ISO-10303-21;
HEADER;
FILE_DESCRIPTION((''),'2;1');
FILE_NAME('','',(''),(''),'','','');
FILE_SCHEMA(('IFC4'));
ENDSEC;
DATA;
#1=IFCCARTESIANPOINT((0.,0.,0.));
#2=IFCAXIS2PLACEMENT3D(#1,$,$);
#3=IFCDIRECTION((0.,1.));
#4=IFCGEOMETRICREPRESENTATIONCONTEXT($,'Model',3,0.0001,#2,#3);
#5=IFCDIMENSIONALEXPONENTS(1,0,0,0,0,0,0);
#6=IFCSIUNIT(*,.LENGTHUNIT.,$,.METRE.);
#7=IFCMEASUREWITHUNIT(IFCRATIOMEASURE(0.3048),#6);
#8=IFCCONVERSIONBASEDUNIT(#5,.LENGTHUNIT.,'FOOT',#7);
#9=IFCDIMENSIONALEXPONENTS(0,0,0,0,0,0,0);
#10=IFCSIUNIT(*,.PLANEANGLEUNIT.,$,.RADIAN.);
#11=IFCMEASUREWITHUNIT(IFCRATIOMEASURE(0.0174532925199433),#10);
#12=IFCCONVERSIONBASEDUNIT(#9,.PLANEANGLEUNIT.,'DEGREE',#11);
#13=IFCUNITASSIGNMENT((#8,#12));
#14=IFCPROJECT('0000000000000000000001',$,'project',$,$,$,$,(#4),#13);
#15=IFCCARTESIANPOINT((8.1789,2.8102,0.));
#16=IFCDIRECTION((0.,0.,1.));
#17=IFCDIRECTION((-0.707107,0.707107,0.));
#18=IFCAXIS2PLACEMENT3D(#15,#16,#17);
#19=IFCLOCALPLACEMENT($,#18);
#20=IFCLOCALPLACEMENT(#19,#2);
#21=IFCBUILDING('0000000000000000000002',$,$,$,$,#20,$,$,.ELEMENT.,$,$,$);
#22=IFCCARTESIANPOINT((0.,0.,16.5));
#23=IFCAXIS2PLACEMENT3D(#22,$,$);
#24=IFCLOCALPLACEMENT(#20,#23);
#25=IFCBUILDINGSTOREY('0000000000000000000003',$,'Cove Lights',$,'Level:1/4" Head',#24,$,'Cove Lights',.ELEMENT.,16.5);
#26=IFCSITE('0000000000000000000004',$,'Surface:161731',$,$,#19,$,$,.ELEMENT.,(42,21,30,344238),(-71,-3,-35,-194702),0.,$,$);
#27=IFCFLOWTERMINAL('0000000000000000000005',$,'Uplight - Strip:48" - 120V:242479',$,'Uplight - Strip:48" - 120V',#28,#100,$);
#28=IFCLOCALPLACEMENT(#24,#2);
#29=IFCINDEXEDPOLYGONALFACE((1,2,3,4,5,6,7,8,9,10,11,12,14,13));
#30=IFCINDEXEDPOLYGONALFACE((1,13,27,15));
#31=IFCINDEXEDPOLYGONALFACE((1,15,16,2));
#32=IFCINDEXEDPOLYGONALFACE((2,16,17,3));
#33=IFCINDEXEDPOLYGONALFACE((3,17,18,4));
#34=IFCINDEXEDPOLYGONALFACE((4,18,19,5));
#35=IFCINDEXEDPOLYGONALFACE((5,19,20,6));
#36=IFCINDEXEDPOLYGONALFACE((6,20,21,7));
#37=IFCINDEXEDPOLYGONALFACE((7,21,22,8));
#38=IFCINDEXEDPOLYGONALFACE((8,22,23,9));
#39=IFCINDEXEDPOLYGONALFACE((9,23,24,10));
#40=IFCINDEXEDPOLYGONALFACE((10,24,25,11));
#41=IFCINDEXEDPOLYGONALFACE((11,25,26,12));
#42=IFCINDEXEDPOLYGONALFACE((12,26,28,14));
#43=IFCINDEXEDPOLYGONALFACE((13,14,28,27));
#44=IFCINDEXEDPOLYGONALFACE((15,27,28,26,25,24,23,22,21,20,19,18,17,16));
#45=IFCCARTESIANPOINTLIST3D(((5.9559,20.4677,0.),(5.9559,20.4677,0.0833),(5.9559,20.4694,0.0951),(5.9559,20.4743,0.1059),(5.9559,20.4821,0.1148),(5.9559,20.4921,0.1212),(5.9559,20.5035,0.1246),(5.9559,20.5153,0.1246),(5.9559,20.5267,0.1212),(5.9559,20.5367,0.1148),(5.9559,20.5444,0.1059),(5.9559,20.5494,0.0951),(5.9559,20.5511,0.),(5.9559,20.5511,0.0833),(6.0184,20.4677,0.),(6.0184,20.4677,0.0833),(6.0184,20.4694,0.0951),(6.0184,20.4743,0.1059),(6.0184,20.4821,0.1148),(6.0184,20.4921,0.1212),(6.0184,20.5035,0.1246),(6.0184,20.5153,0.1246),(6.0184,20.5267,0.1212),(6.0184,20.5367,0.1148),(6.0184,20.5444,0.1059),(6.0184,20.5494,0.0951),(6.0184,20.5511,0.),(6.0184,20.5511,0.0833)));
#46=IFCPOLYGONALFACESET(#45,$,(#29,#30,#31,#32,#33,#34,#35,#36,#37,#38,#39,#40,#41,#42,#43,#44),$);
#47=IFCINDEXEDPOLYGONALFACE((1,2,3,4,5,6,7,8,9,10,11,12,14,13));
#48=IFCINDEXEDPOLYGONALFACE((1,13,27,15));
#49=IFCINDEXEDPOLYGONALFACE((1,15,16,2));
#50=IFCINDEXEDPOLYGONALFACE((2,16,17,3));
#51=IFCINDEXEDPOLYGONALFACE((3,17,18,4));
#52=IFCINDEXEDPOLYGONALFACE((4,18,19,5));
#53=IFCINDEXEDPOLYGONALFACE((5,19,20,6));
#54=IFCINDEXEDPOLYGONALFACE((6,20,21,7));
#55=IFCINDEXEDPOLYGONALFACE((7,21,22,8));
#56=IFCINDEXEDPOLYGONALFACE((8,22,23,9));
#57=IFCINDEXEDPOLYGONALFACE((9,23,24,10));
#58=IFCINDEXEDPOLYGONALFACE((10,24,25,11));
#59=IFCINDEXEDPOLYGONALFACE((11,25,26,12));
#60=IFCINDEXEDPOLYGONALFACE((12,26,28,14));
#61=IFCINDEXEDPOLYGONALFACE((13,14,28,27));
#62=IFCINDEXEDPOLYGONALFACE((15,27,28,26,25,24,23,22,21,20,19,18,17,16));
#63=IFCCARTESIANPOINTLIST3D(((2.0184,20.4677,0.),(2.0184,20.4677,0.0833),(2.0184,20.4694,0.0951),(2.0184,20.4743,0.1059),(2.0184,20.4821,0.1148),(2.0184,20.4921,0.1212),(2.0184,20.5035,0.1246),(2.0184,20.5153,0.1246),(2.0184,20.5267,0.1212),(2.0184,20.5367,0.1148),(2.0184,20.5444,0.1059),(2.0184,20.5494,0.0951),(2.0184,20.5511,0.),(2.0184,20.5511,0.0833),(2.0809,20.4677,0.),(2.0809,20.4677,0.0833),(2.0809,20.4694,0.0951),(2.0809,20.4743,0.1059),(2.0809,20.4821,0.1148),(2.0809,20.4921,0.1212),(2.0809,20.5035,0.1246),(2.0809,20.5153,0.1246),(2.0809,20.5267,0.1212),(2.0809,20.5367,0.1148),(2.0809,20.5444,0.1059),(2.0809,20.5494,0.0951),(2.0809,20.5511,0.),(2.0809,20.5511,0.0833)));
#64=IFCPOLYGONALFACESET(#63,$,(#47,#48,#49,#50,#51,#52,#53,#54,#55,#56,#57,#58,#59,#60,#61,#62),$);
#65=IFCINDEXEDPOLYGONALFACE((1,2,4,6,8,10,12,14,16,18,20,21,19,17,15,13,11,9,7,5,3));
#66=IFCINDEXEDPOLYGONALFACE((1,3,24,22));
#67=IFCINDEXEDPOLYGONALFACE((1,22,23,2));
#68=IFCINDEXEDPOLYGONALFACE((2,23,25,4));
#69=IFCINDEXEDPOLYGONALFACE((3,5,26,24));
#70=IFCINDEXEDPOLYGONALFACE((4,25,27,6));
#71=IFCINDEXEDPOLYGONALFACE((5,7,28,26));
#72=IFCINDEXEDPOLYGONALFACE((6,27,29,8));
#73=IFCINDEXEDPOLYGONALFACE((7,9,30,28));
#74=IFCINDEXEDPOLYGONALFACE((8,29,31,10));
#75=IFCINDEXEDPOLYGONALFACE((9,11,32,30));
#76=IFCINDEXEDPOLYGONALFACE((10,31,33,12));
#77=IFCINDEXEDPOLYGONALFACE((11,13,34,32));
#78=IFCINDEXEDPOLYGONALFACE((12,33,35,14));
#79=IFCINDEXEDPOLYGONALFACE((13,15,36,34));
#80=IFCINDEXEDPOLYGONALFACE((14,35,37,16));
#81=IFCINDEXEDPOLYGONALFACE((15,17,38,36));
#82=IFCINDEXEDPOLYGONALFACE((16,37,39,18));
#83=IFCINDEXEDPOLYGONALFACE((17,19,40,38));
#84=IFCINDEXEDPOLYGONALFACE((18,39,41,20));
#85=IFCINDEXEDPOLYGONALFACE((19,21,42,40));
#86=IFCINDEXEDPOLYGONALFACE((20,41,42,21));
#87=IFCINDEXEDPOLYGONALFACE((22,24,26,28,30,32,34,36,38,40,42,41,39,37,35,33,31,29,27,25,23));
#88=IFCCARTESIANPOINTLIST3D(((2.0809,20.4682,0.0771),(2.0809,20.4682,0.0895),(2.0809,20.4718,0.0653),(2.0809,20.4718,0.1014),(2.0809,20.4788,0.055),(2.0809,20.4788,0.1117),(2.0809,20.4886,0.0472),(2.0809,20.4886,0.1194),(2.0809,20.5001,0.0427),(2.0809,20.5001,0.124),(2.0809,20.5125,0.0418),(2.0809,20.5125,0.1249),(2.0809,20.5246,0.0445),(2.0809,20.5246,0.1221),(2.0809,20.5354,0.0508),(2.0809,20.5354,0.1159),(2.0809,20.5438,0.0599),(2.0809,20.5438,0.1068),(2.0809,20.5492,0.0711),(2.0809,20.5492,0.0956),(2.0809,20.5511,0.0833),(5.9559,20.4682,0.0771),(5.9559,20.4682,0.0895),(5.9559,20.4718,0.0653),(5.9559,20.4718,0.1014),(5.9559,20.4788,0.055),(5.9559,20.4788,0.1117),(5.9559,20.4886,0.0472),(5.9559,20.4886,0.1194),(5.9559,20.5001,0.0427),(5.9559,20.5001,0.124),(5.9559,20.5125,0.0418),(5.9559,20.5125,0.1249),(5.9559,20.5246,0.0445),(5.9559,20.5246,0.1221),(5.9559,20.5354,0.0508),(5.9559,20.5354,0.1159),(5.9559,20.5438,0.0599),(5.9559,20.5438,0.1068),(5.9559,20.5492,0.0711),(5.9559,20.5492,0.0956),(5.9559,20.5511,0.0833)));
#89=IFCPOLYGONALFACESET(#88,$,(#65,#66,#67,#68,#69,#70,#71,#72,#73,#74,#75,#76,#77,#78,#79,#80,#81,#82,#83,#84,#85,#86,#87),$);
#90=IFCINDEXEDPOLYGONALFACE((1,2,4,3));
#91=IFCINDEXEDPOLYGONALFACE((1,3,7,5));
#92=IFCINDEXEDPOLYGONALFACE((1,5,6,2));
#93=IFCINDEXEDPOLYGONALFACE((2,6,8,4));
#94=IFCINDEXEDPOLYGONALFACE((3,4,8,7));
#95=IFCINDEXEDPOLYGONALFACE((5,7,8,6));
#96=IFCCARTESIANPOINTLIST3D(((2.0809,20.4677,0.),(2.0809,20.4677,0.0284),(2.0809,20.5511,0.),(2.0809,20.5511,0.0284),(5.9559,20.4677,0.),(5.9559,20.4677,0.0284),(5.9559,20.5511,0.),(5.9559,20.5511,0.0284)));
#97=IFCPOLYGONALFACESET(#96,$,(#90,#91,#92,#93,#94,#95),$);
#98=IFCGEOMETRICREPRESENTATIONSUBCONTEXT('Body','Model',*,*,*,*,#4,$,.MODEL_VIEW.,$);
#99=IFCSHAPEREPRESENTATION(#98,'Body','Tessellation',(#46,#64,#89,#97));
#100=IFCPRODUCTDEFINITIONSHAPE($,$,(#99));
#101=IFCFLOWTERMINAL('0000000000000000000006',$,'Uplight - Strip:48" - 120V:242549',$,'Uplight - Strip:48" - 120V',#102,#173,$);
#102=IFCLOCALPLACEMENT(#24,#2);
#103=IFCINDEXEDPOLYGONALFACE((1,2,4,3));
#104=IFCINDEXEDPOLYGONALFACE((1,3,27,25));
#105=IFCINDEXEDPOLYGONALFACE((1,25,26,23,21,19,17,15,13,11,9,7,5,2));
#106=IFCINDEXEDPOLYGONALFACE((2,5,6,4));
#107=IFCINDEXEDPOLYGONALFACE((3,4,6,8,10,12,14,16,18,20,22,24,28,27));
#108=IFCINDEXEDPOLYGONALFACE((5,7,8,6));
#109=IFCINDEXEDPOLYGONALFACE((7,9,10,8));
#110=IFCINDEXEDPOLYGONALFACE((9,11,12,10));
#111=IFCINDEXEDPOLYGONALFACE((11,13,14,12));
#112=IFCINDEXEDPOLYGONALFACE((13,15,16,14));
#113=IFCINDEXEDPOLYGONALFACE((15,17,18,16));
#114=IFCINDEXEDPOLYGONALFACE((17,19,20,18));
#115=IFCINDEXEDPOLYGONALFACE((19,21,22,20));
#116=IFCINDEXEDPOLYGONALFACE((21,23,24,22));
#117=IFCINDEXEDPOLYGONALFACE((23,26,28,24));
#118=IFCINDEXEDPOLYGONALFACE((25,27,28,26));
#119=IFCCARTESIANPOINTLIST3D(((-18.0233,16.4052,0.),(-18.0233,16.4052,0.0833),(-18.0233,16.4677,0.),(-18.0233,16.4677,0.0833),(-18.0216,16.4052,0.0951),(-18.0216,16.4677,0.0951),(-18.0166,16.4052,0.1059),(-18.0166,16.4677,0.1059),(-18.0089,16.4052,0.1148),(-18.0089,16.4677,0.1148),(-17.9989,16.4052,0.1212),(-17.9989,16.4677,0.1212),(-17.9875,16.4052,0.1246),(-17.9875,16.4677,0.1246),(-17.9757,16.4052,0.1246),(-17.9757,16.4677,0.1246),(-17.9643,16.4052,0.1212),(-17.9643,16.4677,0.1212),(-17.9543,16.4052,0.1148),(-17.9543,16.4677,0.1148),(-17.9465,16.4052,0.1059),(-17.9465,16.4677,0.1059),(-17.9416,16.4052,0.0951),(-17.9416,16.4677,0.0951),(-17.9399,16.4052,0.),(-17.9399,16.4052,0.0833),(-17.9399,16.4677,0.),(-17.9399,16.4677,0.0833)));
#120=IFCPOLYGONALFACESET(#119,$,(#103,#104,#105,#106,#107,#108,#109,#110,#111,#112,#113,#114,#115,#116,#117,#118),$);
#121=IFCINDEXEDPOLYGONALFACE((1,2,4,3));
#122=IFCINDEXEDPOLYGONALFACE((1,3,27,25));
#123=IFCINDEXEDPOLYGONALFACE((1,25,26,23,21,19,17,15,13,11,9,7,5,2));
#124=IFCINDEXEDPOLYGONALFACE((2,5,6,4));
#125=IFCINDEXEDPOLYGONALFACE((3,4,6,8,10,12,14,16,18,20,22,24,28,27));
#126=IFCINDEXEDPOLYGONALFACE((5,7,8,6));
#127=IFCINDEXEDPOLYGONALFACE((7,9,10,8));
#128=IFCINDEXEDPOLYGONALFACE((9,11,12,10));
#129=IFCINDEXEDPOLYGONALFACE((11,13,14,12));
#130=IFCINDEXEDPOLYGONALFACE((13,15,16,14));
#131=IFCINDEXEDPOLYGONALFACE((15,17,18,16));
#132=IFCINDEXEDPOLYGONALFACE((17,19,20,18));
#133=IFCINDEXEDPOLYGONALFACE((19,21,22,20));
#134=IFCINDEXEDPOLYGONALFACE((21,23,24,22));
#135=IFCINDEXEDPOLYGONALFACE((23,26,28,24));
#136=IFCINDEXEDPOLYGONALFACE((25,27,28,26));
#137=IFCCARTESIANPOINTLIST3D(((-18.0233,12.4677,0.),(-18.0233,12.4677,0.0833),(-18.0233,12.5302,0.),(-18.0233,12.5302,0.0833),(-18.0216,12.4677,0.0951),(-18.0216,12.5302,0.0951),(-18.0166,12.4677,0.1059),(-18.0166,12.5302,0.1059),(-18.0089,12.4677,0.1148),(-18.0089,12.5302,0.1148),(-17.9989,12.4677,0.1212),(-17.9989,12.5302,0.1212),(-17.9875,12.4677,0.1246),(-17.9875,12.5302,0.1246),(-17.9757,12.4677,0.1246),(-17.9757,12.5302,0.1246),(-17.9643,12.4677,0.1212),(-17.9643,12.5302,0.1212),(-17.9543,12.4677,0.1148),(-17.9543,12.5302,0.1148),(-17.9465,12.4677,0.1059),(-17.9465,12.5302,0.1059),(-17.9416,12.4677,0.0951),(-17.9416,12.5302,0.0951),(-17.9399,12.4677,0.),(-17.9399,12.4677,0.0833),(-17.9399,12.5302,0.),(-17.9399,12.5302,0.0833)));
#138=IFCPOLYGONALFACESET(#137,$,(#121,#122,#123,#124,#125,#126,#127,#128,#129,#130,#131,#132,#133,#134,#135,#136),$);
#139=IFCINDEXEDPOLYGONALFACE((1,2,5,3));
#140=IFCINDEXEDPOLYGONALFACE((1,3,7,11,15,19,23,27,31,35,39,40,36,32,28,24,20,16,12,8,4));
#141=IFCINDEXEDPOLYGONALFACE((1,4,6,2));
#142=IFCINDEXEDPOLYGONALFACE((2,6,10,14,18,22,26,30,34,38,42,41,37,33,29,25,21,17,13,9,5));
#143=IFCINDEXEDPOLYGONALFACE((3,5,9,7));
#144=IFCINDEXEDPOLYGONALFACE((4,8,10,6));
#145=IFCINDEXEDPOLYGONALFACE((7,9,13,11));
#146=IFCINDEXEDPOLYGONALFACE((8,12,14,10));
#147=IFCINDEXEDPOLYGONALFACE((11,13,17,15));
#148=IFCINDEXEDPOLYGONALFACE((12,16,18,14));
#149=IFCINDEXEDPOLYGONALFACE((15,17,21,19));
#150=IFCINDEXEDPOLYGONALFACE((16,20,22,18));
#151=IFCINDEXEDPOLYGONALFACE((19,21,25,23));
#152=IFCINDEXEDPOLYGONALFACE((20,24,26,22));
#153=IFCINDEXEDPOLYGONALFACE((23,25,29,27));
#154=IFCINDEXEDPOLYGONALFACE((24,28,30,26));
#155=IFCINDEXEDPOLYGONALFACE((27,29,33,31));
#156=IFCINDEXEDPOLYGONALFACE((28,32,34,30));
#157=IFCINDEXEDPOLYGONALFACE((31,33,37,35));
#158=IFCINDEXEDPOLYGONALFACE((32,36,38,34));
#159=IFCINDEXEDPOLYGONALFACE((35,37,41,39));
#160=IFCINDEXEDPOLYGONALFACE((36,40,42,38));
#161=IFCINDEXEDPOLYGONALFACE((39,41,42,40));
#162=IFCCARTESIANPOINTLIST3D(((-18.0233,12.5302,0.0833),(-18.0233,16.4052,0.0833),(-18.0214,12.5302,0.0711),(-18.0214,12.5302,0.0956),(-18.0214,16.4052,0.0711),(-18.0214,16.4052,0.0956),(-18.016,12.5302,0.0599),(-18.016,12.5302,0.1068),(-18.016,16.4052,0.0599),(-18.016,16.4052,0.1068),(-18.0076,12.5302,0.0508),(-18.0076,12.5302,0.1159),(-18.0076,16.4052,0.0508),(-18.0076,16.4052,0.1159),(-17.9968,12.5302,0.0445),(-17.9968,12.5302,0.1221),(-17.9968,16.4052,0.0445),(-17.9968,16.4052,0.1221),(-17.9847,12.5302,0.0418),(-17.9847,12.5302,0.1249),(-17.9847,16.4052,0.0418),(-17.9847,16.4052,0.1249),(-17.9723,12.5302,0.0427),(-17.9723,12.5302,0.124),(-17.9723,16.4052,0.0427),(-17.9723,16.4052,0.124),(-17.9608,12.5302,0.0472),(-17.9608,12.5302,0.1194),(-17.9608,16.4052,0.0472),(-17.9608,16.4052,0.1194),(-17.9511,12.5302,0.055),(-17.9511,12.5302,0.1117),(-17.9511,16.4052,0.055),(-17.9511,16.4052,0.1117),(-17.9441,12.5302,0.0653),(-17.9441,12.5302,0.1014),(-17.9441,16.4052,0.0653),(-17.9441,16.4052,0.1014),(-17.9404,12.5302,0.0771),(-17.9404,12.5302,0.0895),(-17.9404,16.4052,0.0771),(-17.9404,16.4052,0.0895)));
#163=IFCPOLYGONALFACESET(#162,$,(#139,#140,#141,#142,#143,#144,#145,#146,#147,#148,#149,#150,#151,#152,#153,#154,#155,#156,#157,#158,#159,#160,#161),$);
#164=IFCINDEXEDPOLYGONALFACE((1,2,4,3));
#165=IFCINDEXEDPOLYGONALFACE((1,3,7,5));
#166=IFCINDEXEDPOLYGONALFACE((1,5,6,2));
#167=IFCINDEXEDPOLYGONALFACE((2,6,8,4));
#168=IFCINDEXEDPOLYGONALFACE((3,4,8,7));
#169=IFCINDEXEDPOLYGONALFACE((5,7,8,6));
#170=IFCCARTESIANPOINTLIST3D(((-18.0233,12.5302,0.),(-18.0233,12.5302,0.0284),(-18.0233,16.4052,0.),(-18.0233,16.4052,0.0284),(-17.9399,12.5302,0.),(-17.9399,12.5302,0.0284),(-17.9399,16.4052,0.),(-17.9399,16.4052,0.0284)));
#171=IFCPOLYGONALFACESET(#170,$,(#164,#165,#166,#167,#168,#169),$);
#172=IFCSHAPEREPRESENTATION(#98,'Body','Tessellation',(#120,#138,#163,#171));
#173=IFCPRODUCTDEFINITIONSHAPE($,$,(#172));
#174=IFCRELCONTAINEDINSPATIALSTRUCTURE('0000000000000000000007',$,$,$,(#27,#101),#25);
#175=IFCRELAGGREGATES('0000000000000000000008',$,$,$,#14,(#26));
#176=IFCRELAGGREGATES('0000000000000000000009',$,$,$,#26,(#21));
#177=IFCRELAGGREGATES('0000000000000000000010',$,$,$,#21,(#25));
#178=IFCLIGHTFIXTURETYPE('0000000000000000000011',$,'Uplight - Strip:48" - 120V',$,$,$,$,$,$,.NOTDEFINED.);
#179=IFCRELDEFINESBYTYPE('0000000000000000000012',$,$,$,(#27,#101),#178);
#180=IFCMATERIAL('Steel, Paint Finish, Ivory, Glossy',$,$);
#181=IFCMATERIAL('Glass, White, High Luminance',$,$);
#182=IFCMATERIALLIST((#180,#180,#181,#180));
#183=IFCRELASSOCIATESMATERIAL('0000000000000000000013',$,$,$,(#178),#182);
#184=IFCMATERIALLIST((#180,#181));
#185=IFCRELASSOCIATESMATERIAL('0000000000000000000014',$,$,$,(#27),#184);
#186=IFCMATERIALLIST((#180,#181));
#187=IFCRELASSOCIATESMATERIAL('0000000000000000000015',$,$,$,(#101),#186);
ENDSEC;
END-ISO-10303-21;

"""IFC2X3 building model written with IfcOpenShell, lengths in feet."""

from ifc_helpers import new_model, entity, si_unit, converted_unit, direction, frame, frame_2d, origin, origin_2d_with_axis, place, context, subcontext, project, spatial, polyline, circle_curve, parameter, trimmed, segment, composite_curve, rectangle, circle, outline, extrude, source, transform, mapped, material, material_list, type_object, type_shapes, element, save


model = new_model("IFC2X3")

# Units and contexts
model_context = context("Model", 3, precision=0.0001, world=origin(), true_north=direction((0.0, 1.0)))
body_context = subcontext(model_context, "Body", "Model", "MODEL_VIEW")
ifc_project = project(units=[converted_unit("LENGTHUNIT", "FOOT", entity("IfcRatioMeasure", 0.3048), si_unit("LENGTHUNIT", "METRE"), dimensions=[1, 0, 0, 0, 0, 0, 0]), converted_unit("PLANEANGLEUNIT", "DEGREE", entity("IfcRatioMeasure", 0.0174532925199433), si_unit("PLANEANGLEUNIT", "RADIAN"), dimensions=[0, 0, 0, 0, 0, 0, 0])], contexts=[model_context])

# Site, building, storey
site_placement = place(None, frame((8.1789, 2.8102, 0.0), z_axis=(0.0, 0.0, 1.0), x_axis=(-0.707107, 0.707107, 0.0)))
site = spatial("IfcSite", under=ifc_project, at=site_placement, Name="Surface:161731", CompositionType="ELEMENT", RefLatitude=(42, 21, 30, 344238), RefLongitude=(-71, -3, -35, -194702), RefElevation=0.0)
building_placement = place(site_placement, origin())
building = spatial("IfcBuilding", under=site, at=building_placement, CompositionType="ELEMENT")
storey_placement = place(building_placement, frame((0.0, 0.0, 16.5)))
storey = spatial("IfcBuildingStorey", under=building, at=storey_placement, Name="Cove Lights", ObjectType="Level:1/4\" Head", LongName="Cove Lights", CompositionType="ELEMENT", Elevation=16.5)

# Flow terminals
ifc_material_1 = material(Name="Steel, Paint Finish, Ivory, Glossy")
ifc_material_2 = material(Name="Glass, White, High Luminance")
ifc_material_list_1 = material_list([ifc_material_1, ifc_material_1, ifc_material_2, ifc_material_1])
light_fixture_type_1 = type_object("IfcLightFixtureType", Name="Uplight - Strip:48\" - 120V", PredefinedType="NOTDEFINED", material=ifc_material_list_1)
shared_shape_1 = source(origin(), body_context, "Body", "SweptSolid", [
    extrude(outline(composite_curve([segment(polyline([(-0.0417, -0.0417), (0.0417, -0.0417)]), True, "CONTINUOUS"), segment(trimmed(circle_curve(frame_2d((0.0417, 0.0), x_axis=(0.0, -1.0)), 0.0417), [parameter(0.0)], [parameter(180.0)], True, "PARAMETER"), True, "CONTINUOUS"), segment(polyline([(0.0417, 0.0417), (-0.0417, 0.0417)]), True, "CONTINUOUS"), segment(polyline([(-0.0417, 0.0417), (-0.0417, -0.0417)]), True, "CONTINUOUS")], self_intersect=False)), frame((1.9375, 0.0, 0.0417), z_axis=(1.0, 0.0, 0.0), x_axis=(0.0, 0.0, 1.0)), (0.0, 0.0, 1.0), 0.0625),
    extrude(outline(composite_curve([segment(polyline([(-0.0417, -0.0417), (0.0417, -0.0417)]), True, "CONTINUOUS"), segment(polyline([(0.0417, -0.0417), (0.0417, 0.0417)]), True, "CONTINUOUS"), segment(trimmed(circle_curve(frame_2d((0.0, 0.0417), x_axis=(0.0, 1.0)), 0.0417), [parameter(270.0)], [parameter(90.0)], True, "PARAMETER"), True, "CONTINUOUS"), segment(polyline([(-0.0417, 0.0417), (-0.0417, -0.0417)]), True, "CONTINUOUS")], self_intersect=False)), frame((-2.0, 0.0, 0.0417), z_axis=(1.0, 0.0, 0.0), x_axis=(0.0, 1.0, 0.0)), (0.0, 0.0, 1.0), 0.0625),
    extrude(circle(Radius=0.0417, at=frame_2d((0.0, 0.0), x_axis=(1.0, 0.0))), frame((-1.9375, 0.0, 0.0833), z_axis=(1.0, 0.0, 0.0), x_axis=(0.0, 1.0, 0.0)), (0.0, 0.0, 1.0), 3.875),
    extrude(rectangle(XDim=3.875, YDim=0.0833, at=origin_2d_with_axis()), frame((0.0, 0.0, 0.0), z_axis=(0.0, 0.0, 1.0), x_axis=(-1.0, 0.0, 0.0)), (0.0, 0.0, 1.0), 0.0284),
])
type_shapes(light_fixture_type_1, [shared_shape_1])
ifc_material_list_2 = material_list([ifc_material_1, ifc_material_2])
flow_terminal_1_placement = place(storey_placement, frame((4.0184, 20.5094, 0.0)))
element("IfcFlowTerminal", 1, at=flow_terminal_1_placement, inside=storey, type_object=light_fixture_type_1, material=ifc_material_list_2, Name="Uplight - Strip:48\" - 120V:242479", ObjectType="Uplight - Strip:48\" - 120V", context=body_context, shape_type="MappedRepresentation", body=[
    mapped(shared_shape_1, transform((0.0, 0.0, 0.0), scale=1.0)),
])
ifc_material_list_3 = material_list([ifc_material_1, ifc_material_2])
flow_terminal_2_placement = place(storey_placement, frame((-17.9816, 14.4677, 0.0), z_axis=(0.0, 0.0, 1.0), x_axis=(0.0, 1.0, 0.0)))
element("IfcFlowTerminal", 2, at=flow_terminal_2_placement, inside=storey, type_object=light_fixture_type_1, material=ifc_material_list_3, Name="Uplight - Strip:48\" - 120V:242549", ObjectType="Uplight - Strip:48\" - 120V", context=body_context, shape_type="MappedRepresentation", body=[
    mapped(shared_shape_1, transform((0.0, 0.0, 0.0), scale=1.0)),
])

save(model, "model.ifc")
